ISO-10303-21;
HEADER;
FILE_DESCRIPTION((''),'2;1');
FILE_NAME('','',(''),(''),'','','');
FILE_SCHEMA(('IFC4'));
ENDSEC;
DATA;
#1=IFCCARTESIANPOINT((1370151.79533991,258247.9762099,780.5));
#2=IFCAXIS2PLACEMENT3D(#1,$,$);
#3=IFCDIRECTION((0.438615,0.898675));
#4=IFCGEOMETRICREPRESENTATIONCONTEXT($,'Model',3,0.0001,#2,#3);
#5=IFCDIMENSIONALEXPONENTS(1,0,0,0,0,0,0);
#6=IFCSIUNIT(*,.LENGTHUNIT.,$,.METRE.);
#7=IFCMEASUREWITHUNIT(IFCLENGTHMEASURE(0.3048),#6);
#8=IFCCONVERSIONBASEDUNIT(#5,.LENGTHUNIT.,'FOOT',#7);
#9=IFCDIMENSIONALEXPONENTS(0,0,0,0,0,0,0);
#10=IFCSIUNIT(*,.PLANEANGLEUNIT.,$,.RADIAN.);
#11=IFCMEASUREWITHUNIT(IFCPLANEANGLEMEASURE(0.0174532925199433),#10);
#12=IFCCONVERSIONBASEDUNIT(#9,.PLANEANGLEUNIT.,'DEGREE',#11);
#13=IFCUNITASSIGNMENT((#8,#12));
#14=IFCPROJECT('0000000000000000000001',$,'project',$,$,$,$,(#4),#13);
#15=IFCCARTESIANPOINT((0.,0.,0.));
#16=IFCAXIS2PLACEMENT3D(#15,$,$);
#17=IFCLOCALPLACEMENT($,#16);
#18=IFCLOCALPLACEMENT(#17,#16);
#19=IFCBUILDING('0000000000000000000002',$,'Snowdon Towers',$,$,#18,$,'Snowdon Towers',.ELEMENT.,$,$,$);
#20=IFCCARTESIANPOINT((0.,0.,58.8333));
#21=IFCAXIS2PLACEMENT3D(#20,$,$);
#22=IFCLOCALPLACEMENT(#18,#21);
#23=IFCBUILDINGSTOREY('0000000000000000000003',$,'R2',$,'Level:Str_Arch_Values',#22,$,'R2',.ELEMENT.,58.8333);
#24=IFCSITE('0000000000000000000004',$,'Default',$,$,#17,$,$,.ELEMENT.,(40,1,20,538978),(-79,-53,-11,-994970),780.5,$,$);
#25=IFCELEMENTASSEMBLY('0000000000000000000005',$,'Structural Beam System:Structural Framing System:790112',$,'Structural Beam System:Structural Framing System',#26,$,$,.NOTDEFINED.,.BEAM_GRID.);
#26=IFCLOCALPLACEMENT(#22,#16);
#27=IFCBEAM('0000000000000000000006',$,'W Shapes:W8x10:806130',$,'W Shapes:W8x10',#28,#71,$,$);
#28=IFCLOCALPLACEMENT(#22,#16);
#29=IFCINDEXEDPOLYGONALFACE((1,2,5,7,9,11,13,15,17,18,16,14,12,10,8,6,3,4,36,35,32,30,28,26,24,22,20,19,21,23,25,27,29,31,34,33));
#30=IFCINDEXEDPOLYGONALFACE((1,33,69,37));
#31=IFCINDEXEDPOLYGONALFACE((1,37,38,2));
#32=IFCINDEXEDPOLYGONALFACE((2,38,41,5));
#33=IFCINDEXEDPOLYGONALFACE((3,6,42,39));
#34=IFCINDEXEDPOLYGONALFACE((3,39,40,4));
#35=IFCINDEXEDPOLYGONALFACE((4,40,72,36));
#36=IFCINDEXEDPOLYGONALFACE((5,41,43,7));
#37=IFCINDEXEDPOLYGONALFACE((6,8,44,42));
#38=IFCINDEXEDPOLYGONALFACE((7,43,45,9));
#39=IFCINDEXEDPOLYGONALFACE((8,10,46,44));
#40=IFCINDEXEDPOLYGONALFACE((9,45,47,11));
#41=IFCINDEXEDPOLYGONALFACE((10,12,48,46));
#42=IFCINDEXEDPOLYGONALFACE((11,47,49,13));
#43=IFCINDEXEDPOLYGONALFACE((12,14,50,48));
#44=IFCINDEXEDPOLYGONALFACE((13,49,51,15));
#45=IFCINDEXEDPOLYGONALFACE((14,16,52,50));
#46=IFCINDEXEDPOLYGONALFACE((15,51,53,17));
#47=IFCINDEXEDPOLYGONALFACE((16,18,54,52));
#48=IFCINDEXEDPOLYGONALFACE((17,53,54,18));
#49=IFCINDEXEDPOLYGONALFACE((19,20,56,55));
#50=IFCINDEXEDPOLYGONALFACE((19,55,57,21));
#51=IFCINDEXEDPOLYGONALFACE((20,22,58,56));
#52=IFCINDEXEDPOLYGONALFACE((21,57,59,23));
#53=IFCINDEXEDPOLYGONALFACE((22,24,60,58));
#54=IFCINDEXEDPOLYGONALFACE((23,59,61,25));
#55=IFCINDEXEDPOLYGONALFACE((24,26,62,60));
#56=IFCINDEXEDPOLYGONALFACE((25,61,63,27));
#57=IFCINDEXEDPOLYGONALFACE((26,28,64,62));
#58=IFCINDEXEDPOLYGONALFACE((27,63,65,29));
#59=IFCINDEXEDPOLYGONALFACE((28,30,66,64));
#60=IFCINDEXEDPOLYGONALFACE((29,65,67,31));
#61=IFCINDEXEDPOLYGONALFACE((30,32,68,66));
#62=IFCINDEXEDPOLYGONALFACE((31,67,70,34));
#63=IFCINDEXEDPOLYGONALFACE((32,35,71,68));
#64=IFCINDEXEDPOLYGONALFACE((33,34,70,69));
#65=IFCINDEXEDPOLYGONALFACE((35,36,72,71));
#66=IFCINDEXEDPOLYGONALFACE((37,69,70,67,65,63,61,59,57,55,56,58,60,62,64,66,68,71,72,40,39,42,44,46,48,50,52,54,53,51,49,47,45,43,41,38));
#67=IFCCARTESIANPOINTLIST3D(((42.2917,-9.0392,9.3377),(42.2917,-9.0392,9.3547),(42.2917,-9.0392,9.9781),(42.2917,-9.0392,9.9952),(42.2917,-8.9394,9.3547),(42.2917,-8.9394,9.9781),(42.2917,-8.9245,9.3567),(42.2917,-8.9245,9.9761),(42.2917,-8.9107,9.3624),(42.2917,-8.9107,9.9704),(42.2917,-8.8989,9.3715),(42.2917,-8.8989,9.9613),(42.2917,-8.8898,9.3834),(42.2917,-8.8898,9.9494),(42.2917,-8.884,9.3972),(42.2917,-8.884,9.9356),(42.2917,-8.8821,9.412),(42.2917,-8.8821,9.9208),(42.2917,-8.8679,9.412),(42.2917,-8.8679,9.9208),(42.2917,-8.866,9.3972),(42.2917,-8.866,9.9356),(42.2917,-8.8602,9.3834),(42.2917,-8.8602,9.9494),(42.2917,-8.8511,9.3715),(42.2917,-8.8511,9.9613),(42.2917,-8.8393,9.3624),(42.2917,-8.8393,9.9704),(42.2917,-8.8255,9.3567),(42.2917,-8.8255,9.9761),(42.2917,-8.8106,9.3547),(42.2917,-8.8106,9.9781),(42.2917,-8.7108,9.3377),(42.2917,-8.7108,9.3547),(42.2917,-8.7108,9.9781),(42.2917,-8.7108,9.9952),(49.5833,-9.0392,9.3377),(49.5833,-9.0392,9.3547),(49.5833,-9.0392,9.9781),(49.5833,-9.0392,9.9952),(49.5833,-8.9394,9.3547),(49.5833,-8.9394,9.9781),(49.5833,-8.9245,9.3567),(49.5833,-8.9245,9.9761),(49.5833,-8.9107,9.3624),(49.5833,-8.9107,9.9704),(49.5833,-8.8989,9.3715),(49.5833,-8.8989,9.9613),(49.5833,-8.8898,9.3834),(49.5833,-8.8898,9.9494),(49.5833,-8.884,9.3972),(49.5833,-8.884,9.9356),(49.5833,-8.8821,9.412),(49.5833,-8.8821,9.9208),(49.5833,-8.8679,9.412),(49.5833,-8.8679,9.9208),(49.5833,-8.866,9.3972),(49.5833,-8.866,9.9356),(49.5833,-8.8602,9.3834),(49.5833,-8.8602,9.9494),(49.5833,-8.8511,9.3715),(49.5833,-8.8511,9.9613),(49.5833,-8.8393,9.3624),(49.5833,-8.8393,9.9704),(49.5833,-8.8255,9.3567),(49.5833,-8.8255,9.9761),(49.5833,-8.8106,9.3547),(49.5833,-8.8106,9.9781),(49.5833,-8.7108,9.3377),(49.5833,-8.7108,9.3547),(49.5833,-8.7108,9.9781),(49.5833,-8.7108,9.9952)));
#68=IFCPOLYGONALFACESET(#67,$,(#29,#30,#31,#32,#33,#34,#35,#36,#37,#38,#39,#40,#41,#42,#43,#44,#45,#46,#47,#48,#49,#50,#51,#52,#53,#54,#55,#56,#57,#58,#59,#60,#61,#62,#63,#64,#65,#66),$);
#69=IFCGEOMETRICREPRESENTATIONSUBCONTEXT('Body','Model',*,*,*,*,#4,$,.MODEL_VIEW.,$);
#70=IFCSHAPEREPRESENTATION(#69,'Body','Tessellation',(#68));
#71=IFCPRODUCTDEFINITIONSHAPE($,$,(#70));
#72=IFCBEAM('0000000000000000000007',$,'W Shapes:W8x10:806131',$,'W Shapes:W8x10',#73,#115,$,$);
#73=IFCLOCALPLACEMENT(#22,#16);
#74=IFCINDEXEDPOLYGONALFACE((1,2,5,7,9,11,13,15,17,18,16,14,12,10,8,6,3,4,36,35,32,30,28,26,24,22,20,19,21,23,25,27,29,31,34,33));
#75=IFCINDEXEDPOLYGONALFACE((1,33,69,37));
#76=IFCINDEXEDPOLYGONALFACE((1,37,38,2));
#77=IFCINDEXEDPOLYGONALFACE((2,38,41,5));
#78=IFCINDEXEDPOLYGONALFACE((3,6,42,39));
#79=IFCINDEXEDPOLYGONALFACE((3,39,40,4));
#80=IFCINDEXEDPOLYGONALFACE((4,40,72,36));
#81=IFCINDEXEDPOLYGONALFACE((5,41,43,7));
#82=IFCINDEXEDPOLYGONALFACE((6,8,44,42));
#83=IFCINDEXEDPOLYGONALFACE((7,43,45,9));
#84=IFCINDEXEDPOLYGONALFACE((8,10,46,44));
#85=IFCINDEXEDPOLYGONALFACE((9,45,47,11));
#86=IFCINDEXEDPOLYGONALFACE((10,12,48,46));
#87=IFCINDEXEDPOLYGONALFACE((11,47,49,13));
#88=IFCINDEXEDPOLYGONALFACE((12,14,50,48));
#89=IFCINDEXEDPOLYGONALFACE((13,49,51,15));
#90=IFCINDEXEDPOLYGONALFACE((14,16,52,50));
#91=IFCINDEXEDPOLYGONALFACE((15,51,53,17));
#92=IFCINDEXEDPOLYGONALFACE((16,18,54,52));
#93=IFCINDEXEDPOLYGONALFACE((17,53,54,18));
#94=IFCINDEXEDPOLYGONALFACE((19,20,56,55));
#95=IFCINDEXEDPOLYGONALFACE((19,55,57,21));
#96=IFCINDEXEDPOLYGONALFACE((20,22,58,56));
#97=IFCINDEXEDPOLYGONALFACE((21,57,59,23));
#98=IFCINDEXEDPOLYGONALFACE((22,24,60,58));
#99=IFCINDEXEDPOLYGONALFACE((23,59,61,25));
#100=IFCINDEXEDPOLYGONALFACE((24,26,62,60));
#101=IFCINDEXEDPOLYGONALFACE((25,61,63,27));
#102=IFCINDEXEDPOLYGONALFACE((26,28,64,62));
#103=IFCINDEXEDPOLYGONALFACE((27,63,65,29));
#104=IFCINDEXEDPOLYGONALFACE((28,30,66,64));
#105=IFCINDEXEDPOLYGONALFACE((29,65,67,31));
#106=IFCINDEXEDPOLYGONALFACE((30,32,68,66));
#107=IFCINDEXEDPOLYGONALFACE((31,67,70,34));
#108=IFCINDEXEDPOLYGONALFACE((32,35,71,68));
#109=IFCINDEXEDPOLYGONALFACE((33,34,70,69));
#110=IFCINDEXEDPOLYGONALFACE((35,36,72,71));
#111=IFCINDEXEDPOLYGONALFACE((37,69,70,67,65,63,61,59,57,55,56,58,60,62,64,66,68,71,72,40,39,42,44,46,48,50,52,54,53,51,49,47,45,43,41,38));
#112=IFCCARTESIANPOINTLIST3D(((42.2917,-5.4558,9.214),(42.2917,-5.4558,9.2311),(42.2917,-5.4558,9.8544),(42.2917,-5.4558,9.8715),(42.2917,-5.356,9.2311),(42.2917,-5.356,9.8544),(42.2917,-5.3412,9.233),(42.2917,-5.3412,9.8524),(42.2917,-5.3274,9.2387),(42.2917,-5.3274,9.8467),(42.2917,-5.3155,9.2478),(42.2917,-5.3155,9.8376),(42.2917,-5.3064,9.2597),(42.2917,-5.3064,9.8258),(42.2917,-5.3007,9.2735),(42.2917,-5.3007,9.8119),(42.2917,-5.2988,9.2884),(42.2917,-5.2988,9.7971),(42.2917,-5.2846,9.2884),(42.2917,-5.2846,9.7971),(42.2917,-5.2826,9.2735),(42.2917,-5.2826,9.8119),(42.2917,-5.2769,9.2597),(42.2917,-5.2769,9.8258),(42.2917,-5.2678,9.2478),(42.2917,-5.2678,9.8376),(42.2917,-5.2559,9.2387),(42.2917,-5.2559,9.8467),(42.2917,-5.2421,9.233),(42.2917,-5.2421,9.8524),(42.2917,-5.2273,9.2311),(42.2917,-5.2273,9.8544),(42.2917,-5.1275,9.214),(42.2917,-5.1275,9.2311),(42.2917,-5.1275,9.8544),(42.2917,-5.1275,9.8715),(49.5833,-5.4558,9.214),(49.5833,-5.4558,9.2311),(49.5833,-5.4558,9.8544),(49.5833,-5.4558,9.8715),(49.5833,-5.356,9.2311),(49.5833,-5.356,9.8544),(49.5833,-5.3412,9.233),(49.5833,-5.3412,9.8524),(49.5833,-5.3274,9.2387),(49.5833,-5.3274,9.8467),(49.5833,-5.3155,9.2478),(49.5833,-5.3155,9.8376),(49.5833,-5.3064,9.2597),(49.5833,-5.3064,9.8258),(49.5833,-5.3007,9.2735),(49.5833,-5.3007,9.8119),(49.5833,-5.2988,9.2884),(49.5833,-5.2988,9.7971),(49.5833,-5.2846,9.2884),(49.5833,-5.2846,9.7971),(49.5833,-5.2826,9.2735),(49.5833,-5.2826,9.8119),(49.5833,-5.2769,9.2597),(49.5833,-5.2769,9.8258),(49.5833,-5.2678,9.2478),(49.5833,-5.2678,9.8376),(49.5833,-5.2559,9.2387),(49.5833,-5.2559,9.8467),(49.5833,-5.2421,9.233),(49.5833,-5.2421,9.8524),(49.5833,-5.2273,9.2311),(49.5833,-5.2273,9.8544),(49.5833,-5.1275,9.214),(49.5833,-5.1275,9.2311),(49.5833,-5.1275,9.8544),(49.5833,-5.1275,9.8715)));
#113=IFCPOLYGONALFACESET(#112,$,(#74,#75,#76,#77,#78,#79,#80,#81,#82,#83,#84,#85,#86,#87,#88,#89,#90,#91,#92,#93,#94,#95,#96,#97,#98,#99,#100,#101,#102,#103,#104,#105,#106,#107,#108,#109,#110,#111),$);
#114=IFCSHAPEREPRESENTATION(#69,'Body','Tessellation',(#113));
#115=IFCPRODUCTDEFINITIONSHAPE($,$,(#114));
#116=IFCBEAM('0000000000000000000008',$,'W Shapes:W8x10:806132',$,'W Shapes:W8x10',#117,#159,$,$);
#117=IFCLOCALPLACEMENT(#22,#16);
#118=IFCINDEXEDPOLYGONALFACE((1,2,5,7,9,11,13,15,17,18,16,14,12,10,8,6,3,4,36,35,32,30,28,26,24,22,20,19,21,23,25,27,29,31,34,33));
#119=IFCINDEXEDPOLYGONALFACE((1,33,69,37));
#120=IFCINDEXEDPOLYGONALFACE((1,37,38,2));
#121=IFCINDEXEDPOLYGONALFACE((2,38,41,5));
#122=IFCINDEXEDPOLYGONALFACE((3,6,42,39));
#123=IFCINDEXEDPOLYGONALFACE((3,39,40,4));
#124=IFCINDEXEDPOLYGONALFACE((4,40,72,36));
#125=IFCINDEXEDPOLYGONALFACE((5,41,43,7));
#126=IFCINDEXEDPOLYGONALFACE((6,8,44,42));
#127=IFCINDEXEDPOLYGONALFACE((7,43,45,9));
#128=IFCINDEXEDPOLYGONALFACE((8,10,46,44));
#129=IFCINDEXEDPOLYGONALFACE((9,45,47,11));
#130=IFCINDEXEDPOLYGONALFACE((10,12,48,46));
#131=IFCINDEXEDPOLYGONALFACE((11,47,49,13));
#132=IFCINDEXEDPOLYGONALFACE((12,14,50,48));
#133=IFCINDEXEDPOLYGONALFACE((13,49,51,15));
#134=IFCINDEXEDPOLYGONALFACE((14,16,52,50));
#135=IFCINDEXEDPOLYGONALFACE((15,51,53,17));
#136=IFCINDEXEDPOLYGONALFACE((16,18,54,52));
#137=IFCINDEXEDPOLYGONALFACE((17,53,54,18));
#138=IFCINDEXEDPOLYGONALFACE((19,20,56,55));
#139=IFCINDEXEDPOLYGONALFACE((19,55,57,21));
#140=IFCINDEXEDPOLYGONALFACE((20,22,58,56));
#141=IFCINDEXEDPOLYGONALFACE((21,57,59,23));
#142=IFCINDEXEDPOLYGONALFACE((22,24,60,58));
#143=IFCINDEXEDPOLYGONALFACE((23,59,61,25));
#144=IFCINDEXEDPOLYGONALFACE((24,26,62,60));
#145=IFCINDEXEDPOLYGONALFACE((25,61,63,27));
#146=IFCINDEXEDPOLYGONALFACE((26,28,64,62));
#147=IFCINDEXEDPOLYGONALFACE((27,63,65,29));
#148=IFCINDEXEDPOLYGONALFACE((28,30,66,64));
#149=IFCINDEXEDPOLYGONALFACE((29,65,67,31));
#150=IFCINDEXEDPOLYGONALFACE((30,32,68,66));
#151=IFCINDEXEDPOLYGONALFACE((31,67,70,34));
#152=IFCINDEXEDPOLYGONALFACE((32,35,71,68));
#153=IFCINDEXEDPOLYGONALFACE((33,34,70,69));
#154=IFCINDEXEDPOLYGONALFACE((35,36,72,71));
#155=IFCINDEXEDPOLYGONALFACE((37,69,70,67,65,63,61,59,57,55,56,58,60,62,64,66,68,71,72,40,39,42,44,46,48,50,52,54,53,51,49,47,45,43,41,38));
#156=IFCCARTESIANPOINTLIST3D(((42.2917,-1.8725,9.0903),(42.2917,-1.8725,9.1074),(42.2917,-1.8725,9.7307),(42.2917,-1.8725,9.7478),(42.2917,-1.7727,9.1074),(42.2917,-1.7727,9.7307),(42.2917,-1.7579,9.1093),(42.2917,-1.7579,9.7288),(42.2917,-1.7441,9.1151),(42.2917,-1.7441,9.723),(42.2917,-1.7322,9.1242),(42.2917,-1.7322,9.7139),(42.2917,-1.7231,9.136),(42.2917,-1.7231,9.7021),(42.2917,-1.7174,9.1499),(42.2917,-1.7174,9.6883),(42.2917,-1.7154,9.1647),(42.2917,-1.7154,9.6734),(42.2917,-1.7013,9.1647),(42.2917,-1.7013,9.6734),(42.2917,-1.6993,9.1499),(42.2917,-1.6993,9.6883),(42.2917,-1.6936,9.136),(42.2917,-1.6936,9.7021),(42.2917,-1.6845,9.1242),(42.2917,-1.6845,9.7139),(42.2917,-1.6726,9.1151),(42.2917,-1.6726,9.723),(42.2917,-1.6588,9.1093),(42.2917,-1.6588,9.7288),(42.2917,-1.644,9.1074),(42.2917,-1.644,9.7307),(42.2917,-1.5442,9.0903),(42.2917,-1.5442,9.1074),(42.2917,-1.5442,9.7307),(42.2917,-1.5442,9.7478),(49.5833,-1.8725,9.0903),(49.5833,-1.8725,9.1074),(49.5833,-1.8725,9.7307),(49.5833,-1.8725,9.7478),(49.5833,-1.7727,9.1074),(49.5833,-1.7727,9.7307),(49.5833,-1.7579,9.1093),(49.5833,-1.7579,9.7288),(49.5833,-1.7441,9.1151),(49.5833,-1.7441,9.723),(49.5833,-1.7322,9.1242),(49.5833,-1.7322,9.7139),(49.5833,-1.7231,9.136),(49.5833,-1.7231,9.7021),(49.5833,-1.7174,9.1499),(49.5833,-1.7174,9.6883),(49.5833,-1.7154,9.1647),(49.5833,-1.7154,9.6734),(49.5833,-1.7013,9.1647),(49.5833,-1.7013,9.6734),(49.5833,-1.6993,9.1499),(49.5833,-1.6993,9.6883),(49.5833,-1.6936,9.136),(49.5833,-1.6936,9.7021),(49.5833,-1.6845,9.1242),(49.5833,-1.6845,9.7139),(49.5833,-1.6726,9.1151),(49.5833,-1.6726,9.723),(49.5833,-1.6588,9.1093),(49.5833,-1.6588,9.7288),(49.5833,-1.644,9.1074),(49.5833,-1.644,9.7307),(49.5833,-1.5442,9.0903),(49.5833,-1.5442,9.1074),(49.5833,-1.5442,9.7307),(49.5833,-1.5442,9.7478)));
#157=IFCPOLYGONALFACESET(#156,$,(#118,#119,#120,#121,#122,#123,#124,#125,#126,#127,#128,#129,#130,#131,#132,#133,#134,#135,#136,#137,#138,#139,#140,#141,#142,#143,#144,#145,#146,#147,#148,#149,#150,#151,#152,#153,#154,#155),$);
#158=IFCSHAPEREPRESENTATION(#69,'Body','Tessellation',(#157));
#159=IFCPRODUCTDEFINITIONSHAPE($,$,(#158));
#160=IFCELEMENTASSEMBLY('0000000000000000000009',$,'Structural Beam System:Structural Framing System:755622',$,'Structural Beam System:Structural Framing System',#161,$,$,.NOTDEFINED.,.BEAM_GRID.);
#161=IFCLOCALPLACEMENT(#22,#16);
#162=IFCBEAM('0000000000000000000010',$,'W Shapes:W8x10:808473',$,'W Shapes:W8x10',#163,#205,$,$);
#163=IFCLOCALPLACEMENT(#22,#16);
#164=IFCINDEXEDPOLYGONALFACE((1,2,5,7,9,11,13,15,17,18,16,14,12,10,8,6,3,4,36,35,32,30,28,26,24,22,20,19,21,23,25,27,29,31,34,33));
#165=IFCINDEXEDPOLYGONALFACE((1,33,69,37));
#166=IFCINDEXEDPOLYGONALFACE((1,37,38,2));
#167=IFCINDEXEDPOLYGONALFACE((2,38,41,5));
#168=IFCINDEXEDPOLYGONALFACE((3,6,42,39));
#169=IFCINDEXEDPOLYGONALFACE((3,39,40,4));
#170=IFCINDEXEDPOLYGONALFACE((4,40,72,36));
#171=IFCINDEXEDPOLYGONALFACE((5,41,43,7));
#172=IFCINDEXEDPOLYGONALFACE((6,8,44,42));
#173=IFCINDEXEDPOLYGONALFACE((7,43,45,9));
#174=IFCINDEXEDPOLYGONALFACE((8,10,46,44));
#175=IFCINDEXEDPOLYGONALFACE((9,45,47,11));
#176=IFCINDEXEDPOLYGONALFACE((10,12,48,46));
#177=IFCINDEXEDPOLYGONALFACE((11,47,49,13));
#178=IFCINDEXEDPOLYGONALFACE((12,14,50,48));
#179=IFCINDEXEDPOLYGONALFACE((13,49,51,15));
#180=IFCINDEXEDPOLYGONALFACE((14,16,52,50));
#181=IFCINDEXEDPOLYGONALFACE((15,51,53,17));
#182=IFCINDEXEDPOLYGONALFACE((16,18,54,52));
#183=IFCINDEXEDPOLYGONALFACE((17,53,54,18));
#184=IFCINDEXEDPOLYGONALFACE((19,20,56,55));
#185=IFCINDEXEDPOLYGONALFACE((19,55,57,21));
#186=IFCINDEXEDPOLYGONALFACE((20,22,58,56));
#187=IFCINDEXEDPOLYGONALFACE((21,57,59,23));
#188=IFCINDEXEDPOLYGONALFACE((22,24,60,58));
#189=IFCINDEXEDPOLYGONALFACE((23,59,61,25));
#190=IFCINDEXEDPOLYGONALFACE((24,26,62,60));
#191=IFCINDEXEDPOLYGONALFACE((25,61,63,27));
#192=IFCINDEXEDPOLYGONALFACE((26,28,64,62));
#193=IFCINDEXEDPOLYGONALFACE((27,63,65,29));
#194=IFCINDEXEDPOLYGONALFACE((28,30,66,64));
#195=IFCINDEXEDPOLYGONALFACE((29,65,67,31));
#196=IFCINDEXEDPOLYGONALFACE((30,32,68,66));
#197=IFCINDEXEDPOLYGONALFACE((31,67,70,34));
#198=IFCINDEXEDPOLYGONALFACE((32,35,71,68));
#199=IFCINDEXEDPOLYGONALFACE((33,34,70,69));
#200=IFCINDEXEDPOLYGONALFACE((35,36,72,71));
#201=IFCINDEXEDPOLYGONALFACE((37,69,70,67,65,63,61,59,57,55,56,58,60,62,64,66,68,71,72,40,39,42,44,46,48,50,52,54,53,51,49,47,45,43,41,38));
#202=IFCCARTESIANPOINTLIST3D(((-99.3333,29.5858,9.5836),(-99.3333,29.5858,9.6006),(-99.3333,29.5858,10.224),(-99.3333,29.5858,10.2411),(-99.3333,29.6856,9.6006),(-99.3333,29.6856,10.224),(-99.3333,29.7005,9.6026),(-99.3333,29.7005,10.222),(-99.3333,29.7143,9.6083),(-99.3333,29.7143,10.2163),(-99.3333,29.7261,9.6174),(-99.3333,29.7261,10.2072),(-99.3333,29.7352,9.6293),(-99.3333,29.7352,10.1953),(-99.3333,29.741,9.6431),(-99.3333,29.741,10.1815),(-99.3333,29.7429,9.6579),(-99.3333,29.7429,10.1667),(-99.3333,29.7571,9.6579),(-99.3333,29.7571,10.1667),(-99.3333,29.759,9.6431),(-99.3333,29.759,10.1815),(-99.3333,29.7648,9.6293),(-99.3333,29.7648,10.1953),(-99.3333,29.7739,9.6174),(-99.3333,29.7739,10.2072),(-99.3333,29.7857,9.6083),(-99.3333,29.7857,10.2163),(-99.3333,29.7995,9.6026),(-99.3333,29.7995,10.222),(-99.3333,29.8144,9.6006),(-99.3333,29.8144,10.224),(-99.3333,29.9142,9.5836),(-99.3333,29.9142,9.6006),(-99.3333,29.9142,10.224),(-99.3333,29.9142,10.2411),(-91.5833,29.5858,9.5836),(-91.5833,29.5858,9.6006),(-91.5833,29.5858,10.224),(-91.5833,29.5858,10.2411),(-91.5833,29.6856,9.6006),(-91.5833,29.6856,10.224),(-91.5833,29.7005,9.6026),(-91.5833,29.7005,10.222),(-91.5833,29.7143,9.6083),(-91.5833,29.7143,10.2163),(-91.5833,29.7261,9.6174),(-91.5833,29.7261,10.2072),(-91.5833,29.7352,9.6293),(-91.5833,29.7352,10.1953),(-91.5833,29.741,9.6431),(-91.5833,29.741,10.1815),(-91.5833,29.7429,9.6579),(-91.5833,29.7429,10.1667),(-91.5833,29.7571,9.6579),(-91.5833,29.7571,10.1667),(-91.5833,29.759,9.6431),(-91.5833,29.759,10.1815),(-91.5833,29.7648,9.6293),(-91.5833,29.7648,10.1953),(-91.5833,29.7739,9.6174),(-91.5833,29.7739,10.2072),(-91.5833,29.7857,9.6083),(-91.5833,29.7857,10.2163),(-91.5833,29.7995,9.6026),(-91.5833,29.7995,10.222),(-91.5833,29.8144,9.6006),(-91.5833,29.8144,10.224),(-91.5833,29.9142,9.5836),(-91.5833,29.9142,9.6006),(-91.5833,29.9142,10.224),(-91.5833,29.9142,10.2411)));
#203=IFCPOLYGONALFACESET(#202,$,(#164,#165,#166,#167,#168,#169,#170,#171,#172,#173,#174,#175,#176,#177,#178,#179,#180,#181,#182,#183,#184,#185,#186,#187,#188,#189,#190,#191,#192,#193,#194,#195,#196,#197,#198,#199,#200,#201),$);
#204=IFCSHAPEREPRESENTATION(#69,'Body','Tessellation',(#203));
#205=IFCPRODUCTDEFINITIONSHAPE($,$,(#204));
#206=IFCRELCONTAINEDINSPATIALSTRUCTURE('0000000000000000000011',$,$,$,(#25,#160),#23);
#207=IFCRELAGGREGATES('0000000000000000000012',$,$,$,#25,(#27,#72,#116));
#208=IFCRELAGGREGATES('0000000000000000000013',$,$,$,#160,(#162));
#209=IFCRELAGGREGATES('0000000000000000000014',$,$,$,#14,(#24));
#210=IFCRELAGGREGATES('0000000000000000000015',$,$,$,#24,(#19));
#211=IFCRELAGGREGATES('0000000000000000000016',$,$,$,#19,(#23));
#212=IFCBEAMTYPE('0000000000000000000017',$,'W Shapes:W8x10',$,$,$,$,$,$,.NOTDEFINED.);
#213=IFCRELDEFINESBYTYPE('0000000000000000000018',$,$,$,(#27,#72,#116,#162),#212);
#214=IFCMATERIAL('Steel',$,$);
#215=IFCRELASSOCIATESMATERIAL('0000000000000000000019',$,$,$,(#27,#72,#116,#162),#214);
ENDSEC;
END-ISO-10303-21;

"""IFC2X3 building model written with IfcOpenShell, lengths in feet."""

from ifc_helpers import new_model, entity, si_unit, converted_unit, direction, frame, frame_2d, origin, place, context, subcontext, project, spatial, i_section, extrude, material, type_object, element, aggregate, save


model = new_model("IFC2X3")

# Units and contexts
model_context = context("Model", 3, precision=0.0001, world=frame((1370151.79533991, 258247.9762099, 780.5)), true_north=direction((0.438615, 0.898675)))
body_context = subcontext(model_context, "Body", "Model", "MODEL_VIEW")
ifc_project = project(units=[converted_unit("LENGTHUNIT", "FOOT", entity("IfcLengthMeasure", 0.3048), si_unit("LENGTHUNIT", "METRE"), dimensions=[1, 0, 0, 0, 0, 0, 0]), converted_unit("PLANEANGLEUNIT", "DEGREE", entity("IfcPlaneAngleMeasure", 0.0174532925199433), si_unit("PLANEANGLEUNIT", "RADIAN"), dimensions=[0, 0, 0, 0, 0, 0, 0])], contexts=[model_context])

# Site, building, storey
site_placement = place(None, origin())
site = spatial("IfcSite", under=ifc_project, at=site_placement, Name="Default", CompositionType="ELEMENT", RefLatitude=(40, 1, 20, 538978), RefLongitude=(-79, -53, -11, -994970), RefElevation=780.5)
building_placement = place(site_placement, origin())
building = spatial("IfcBuilding", under=site, at=building_placement, Name="Snowdon Towers", LongName="Snowdon Towers", CompositionType="ELEMENT")
storey_placement = place(building_placement, frame((0.0, 0.0, 58.8333)))
storey = spatial("IfcBuildingStorey", under=building, at=storey_placement, Name="R2", ObjectType="Level:Str_Arch_Values", LongName="R2", CompositionType="ELEMENT", Elevation=58.8333)

# Element assembly, beams
ifc_material_1 = material(Name="Steel")
beam_type = type_object("IfcBeamType", Name="W Shapes:W8x10", PredefinedType="NOTDEFINED")
assembly_1_placement = place(storey_placement, origin())
assembly_1 = element("IfcElementAssembly", 1, at=assembly_1_placement, inside=storey, Name="Structural Beam System:Structural Framing System:790112", ObjectType="Structural Beam System:Structural Framing System", AssemblyPlace="NOTDEFINED", PredefinedType="BEAM_GRID")
beam_1_placement = place(assembly_1_placement, frame((50.125, -8.875, 9.9952), z_axis=(0.0, 0.0, 1.0), x_axis=(-1.0, 0.0, 0.0)))
beam_1 = element("IfcBeam", 2, at=beam_1_placement, type_object=beam_type, material=ifc_material_1, Name="W Shapes:W8x10:806130", ObjectType="W Shapes:W8x10", context=body_context, shape_type="SweptSolid", body=[
    extrude(i_section(OverallWidth=0.3283, OverallDepth=0.6575, WebThickness=0.0142, FlangeThickness=0.0171, FilletRadius=0.0573, at=frame_2d((0.0, 0.0), x_axis=(0.0, 1.0))), frame((0.5417, 0.0, -0.3288), z_axis=(1.0, 0.0, 0.0), x_axis=(0.0, 0.0, -1.0)), (0.0, 0.0, 1.0), 7.2917),
])
beam_2_placement = place(assembly_1_placement, frame((50.125, -5.2917, 9.8715), z_axis=(0.0, 0.0, 1.0), x_axis=(-1.0, 0.0, 0.0)))
beam_2 = element("IfcBeam", 3, at=beam_2_placement, type_object=beam_type, material=ifc_material_1, Name="W Shapes:W8x10:806131", ObjectType="W Shapes:W8x10", context=body_context, shape_type="SweptSolid", body=[
    extrude(i_section(OverallWidth=0.3283, OverallDepth=0.6575, WebThickness=0.0142, FlangeThickness=0.0171, FilletRadius=0.0573, at=frame_2d((0.0, 0.0), x_axis=(0.0, 1.0))), frame((0.5417, 0.0, -0.3288), z_axis=(1.0, 0.0, 0.0), x_axis=(0.0, 0.0, -1.0)), (0.0, 0.0, 1.0), 7.2917),
])
beam_3_placement = place(assembly_1_placement, frame((50.125, -1.7083, 9.7478), z_axis=(0.0, 0.0, 1.0), x_axis=(-1.0, 0.0, 0.0)))
beam_3 = element("IfcBeam", 4, at=beam_3_placement, type_object=beam_type, material=ifc_material_1, Name="W Shapes:W8x10:806132", ObjectType="W Shapes:W8x10", context=body_context, shape_type="SweptSolid", body=[
    extrude(i_section(OverallWidth=0.3283, OverallDepth=0.6575, WebThickness=0.0142, FlangeThickness=0.0171, FilletRadius=0.0573, at=frame_2d((0.0, 0.0), x_axis=(0.0, 1.0))), frame((0.5417, 0.0, -0.3288), z_axis=(1.0, 0.0, 0.0), x_axis=(0.0, 0.0, -1.0)), (0.0, 0.0, 1.0), 7.2917),
])
aggregate(assembly_1, [beam_1, beam_2, beam_3])

# Element assembly, beam
assembly_2_placement = place(storey_placement, origin())
assembly_2 = element("IfcElementAssembly", 5, at=assembly_2_placement, inside=storey, Name="Structural Beam System:Structural Framing System:755622", ObjectType="Structural Beam System:Structural Framing System", AssemblyPlace="NOTDEFINED", PredefinedType="BEAM_GRID")
beam_4_placement = place(assembly_2_placement, frame((-91.2917, 29.75, 10.2411), z_axis=(0.0, 0.0, 1.0), x_axis=(-1.0, 0.0, 0.0)))
beam_4 = element("IfcBeam", 6, at=beam_4_placement, type_object=beam_type, material=ifc_material_1, Name="W Shapes:W8x10:808473", ObjectType="W Shapes:W8x10", context=body_context, shape_type="SweptSolid", body=[
    extrude(i_section(OverallWidth=0.3283, OverallDepth=0.6575, WebThickness=0.0142, FlangeThickness=0.0171, FilletRadius=0.0573, at=frame_2d((0.0, 0.0), x_axis=(0.0, 1.0))), frame((0.2917, 0.0, -0.3288), z_axis=(1.0, 0.0, 0.0), x_axis=(0.0, 0.0, -1.0)), (0.0, 0.0, 1.0), 7.75),
])
aggregate(assembly_2, [beam_4])

save(model, "model.ifc")
